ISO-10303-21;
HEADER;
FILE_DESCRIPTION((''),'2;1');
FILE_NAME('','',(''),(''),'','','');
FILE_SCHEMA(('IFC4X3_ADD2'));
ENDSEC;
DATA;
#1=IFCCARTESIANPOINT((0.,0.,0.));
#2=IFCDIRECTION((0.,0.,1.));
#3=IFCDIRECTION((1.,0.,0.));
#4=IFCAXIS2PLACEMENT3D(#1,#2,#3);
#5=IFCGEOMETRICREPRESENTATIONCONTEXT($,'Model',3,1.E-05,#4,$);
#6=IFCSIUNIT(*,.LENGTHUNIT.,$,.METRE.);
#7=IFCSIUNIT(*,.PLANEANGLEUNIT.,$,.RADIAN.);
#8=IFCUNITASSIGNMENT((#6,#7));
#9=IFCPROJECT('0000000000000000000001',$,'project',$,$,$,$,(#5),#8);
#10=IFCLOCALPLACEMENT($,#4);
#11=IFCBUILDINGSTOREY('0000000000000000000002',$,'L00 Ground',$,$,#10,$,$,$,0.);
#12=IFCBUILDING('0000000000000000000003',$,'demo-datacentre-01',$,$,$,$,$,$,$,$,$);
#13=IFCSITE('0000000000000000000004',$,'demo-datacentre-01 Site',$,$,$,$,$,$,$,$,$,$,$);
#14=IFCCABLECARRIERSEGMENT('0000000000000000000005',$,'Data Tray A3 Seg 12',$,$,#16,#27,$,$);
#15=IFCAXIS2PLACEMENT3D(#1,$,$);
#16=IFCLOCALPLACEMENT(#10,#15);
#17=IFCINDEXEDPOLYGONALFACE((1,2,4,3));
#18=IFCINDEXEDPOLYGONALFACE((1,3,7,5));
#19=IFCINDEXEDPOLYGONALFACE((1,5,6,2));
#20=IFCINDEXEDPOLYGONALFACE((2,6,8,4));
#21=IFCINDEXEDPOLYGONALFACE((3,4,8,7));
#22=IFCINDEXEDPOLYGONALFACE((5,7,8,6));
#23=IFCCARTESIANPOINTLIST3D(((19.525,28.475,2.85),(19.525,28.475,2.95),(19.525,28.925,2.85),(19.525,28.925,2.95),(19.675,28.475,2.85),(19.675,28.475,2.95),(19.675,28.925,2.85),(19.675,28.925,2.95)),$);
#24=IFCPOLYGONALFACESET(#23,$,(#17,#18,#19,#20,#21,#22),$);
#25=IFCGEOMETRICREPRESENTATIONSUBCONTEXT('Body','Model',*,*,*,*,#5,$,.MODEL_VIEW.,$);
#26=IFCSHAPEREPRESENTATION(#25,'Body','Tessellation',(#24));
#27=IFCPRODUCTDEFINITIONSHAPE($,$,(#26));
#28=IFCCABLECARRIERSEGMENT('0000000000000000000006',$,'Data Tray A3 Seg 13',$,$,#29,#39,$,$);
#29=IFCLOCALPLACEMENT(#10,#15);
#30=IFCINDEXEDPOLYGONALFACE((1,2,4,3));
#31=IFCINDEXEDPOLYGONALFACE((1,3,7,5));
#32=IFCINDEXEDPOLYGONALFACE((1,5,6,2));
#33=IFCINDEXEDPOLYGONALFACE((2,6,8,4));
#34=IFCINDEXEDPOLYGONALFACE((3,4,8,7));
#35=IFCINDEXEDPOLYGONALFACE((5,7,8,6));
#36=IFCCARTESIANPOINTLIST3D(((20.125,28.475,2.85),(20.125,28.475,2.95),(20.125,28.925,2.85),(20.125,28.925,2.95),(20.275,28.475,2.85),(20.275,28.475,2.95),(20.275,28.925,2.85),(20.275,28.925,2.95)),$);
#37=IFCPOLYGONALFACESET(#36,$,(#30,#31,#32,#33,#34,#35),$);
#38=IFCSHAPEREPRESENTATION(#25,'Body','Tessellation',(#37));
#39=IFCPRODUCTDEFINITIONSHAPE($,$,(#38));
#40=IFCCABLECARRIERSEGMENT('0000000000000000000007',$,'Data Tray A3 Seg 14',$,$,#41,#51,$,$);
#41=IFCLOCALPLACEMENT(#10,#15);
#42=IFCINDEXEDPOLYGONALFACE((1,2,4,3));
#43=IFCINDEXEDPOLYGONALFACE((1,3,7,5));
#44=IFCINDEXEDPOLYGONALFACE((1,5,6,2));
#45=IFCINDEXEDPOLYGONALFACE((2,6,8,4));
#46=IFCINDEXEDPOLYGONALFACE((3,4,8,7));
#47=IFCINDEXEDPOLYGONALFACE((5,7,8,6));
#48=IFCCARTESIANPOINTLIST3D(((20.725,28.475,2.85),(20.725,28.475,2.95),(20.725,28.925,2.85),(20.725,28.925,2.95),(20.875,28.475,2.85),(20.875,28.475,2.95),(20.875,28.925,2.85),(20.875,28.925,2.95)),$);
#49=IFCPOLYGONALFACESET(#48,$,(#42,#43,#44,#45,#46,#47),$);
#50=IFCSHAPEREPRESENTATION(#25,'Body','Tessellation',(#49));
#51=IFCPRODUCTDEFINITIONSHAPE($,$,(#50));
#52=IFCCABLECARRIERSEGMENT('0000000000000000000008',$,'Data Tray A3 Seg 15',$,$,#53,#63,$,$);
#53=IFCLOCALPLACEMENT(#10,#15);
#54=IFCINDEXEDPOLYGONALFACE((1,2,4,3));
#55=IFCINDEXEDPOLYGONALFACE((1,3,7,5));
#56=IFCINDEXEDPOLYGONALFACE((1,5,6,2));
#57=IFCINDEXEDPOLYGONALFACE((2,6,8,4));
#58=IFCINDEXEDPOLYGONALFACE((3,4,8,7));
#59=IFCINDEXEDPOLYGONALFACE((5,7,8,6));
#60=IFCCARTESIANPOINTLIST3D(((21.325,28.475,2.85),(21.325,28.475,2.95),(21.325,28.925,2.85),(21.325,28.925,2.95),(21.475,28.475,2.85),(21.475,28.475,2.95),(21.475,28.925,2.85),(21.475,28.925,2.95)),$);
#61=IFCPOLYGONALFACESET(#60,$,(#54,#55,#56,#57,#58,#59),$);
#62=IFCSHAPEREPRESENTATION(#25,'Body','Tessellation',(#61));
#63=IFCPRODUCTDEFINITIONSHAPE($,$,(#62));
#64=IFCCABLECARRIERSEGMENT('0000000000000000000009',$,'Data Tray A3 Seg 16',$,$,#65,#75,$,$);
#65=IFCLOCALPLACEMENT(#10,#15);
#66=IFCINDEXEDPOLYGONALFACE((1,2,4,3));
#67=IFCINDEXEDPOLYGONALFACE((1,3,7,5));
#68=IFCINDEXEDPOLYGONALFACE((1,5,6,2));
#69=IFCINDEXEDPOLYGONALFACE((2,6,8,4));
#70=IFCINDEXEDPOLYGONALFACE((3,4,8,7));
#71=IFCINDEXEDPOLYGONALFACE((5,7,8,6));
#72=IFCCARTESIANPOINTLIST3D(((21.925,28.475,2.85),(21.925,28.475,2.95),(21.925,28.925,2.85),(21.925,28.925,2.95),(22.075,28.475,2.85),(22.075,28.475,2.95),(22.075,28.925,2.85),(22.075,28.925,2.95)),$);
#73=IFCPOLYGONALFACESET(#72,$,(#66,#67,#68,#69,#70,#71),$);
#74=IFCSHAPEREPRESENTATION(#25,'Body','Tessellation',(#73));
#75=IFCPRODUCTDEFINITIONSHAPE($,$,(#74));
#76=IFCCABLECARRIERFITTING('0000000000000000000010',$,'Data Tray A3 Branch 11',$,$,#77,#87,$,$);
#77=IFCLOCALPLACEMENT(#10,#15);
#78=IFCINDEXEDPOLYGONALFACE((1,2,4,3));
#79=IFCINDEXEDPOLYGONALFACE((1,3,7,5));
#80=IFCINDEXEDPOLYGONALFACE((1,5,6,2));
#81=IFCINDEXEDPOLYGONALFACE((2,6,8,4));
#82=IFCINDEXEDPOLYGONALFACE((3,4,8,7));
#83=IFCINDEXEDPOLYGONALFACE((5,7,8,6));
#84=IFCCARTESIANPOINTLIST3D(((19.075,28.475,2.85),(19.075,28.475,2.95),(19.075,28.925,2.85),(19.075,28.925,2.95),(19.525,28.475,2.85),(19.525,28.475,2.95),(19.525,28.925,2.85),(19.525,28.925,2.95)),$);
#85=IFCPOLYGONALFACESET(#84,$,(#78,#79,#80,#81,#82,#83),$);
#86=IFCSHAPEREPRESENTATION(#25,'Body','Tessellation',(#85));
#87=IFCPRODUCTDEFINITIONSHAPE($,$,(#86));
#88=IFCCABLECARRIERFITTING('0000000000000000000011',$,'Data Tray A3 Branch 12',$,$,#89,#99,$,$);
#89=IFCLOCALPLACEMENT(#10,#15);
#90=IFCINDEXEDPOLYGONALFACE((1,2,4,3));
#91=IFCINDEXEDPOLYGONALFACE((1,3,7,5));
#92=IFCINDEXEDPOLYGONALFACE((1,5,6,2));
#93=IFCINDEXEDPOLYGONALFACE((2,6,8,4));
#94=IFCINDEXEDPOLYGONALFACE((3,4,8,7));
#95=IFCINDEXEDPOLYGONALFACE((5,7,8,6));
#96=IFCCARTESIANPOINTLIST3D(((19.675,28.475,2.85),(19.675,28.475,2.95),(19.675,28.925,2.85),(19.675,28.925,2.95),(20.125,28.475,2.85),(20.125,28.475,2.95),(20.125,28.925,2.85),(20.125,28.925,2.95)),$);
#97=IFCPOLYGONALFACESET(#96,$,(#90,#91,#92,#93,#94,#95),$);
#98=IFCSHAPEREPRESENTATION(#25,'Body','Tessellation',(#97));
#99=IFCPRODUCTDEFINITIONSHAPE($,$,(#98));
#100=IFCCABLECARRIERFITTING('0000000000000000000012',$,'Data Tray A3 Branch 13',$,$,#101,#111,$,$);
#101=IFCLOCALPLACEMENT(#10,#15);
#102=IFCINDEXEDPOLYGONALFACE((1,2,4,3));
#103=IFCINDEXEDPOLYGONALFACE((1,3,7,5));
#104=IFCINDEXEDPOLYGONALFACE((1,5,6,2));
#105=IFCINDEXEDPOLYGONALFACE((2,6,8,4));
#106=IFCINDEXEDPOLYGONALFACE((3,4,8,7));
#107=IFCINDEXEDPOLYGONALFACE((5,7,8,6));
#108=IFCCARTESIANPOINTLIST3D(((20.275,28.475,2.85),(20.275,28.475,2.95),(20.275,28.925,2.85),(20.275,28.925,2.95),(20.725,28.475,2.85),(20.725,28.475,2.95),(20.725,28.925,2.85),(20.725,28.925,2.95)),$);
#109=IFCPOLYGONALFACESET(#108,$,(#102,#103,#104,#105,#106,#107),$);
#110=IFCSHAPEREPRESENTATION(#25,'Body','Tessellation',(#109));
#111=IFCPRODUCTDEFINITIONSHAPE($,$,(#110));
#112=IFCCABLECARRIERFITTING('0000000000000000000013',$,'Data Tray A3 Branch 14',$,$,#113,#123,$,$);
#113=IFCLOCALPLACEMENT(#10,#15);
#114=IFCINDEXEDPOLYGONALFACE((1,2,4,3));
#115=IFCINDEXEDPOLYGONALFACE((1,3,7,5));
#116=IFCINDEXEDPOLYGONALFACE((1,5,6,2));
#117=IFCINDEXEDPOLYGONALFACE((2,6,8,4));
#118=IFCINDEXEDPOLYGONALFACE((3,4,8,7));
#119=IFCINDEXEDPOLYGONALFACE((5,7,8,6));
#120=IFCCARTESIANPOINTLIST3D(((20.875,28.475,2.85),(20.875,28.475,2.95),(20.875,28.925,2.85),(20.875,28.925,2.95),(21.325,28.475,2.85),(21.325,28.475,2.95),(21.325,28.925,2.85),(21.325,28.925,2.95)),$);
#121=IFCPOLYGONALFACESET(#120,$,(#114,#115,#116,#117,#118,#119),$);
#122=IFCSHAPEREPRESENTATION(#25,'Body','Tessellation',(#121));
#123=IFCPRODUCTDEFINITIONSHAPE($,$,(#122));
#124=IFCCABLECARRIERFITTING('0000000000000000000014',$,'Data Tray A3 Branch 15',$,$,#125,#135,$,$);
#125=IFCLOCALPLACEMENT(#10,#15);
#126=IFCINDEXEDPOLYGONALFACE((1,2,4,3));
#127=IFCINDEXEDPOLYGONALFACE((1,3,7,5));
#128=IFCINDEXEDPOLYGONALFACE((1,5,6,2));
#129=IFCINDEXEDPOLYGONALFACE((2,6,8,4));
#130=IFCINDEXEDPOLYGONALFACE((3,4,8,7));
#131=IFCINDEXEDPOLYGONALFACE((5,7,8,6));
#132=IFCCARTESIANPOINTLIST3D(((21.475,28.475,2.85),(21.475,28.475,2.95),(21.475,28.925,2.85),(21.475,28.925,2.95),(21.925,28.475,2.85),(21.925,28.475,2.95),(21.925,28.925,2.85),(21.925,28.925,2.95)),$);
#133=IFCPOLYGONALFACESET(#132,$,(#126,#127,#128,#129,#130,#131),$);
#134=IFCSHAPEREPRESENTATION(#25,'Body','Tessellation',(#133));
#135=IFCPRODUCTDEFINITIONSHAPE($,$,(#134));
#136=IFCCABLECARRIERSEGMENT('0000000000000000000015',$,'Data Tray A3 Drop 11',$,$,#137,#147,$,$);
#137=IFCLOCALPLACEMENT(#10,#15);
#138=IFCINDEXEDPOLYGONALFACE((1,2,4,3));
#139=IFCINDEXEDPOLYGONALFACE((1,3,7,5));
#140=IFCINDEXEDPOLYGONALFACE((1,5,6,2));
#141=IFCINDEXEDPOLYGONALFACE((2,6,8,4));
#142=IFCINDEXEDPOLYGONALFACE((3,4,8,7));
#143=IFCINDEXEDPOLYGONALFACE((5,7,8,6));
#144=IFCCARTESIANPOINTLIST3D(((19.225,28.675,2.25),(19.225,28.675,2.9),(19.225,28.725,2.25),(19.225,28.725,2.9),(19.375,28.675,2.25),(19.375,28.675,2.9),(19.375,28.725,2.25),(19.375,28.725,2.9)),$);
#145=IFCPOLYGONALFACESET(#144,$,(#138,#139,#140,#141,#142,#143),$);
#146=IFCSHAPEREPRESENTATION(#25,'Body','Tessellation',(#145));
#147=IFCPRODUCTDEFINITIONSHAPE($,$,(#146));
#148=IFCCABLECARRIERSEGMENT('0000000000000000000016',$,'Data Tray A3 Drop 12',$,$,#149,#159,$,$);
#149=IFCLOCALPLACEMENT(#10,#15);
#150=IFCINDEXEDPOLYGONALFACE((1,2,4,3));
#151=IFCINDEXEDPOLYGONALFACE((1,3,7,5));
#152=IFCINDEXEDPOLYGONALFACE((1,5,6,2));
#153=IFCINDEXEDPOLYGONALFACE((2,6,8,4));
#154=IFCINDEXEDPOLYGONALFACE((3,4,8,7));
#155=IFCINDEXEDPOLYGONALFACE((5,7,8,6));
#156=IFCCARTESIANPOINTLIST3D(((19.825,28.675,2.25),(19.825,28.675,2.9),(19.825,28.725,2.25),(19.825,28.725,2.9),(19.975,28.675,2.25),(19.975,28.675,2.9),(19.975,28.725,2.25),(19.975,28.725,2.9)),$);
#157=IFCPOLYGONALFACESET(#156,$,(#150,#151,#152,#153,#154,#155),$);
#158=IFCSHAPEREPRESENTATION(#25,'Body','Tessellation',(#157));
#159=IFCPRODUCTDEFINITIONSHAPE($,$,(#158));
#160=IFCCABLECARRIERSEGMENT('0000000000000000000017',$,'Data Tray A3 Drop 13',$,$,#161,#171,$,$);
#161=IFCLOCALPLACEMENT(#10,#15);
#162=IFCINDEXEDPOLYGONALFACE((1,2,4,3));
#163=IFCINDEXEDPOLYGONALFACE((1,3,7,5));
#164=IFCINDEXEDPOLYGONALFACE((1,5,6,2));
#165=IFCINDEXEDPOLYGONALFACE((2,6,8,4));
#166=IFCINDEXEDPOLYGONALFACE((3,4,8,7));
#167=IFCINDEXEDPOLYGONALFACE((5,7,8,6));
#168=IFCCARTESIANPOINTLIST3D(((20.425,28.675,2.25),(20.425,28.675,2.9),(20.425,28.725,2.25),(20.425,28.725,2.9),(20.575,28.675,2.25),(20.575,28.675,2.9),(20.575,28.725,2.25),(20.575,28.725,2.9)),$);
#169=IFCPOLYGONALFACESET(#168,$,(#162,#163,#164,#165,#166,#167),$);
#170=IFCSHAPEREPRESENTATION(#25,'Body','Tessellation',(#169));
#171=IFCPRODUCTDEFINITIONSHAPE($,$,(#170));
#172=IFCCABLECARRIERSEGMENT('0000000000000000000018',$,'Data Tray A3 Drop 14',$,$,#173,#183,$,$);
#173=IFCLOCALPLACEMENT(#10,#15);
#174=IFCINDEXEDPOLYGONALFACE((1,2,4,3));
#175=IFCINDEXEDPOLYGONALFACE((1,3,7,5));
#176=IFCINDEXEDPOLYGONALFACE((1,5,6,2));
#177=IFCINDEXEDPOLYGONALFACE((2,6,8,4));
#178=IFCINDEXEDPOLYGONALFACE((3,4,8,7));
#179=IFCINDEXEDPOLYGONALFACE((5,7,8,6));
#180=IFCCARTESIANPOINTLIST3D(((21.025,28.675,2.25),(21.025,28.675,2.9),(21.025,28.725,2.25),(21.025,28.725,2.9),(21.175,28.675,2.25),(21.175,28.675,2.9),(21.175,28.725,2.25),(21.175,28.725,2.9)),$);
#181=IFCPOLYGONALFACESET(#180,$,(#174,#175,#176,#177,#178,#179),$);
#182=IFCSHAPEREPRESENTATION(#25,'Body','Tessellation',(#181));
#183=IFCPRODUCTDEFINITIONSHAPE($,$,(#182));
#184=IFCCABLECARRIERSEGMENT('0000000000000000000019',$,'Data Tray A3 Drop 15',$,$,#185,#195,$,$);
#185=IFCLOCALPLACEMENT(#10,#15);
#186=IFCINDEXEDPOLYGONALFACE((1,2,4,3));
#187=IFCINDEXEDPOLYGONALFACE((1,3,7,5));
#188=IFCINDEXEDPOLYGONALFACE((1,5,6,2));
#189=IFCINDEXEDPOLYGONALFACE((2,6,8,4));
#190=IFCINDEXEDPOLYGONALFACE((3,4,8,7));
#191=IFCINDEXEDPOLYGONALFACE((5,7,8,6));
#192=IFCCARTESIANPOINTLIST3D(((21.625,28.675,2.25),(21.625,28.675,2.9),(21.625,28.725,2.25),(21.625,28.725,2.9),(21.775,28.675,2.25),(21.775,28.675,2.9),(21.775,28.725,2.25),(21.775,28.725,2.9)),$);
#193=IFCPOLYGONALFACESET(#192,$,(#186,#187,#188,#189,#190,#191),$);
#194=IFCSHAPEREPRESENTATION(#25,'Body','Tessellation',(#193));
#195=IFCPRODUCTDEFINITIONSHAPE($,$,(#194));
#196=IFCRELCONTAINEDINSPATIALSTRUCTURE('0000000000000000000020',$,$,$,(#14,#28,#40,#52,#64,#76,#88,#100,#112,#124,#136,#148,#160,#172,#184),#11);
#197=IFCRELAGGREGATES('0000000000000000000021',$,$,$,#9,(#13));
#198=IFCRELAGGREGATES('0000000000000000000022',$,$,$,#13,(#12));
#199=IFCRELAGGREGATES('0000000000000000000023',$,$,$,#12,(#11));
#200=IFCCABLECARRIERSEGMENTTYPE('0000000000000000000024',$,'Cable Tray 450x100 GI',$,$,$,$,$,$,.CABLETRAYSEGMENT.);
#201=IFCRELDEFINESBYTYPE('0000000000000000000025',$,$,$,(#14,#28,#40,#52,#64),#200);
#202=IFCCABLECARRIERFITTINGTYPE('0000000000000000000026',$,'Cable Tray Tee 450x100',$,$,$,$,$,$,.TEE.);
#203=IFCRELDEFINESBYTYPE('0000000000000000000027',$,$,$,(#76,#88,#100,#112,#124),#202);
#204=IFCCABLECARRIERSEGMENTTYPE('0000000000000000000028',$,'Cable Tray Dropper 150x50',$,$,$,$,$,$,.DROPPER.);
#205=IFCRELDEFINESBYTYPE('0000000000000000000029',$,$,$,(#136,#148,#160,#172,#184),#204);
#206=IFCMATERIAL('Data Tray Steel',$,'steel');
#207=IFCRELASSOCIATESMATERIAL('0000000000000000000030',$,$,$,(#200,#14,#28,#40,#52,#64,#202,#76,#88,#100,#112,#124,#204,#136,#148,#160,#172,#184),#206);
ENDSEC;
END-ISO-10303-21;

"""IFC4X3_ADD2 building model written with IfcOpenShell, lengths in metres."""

from ifc_helpers import new_model, si_unit, frame, origin_with_axes, place, context, subcontext, project, spatial, rectangle, extrude, material, type_object, element, save


model = new_model("IFC4X3_ADD2")

# Units and contexts
model_context = context("Model", 3, precision=1e-05, world=origin_with_axes())
body_context = subcontext(model_context, "Body", "Model", "MODEL_VIEW")
ifc_project = project(units=[si_unit("LENGTHUNIT", "METRE"), si_unit("PLANEANGLEUNIT", "RADIAN")], contexts=[model_context])

# Site, building, storey
site = spatial("IfcSite", under=ifc_project, Name="demo-datacentre-01 Site")
building = spatial("IfcBuilding", under=site, Name="demo-datacentre-01")
storey_placement = place(None, origin_with_axes())
storey = spatial("IfcBuildingStorey", under=building, at=storey_placement, Name="L00 Ground", Elevation=0.0)

# Cable carrier segments
ifc_material_1 = material(Name="Data Tray Steel", Category="steel")
cable_carrier_segment_type_1 = type_object("IfcCableCarrierSegmentType", Name="Cable Tray 450x100 GI", PredefinedType="CABLETRAYSEGMENT", material=ifc_material_1)
cable_carrier_segment_1_placement = place(storey_placement, frame((19.525, 28.7, 2.9), z_axis=(1.0, 0.0, 0.0), x_axis=(0.0, 1.0, 0.0)))
element("IfcCableCarrierSegment", 1, at=cable_carrier_segment_1_placement, inside=storey, type_object=cable_carrier_segment_type_1, material=ifc_material_1, Name="Data Tray A3 Seg 12", context=body_context, shape_type="SweptSolid", body=[
    extrude(rectangle(XDim=0.45, YDim=0.1), origin_with_axes(), (0.0, 0.0, 1.0), 0.15),
])
for number, where, z_axis, x_axis, name in (
    (2, (20.125, 28.7, 2.9), (1.0, 0.0, 0.0), (0.0, 1.0, 0.0), "Data Tray A3 Seg 13"),
    (3, (20.725, 28.7, 2.9), (1.0, 0.0, 0.0), (0.0, 1.0, 0.0), "Data Tray A3 Seg 14"),
    (4, (21.325, 28.7, 2.9), (1.0, 0.0, 0.0), (0.0, 1.0, 0.0), "Data Tray A3 Seg 15"),
):
    element("IfcCableCarrierSegment", number, at=place(storey_placement, frame(where, z_axis=z_axis, x_axis=x_axis)), inside=storey, type_object=cable_carrier_segment_type_1, material=ifc_material_1, Name=name, context=body_context, shape_type="SweptSolid", body=[
        extrude(rectangle(XDim=0.45, YDim=0.1), origin_with_axes(), (0.0, 0.0, 1.0), 0.15),
    ])
cable_carrier_segment_2_placement = place(storey_placement, frame((21.925, 28.7, 2.9), z_axis=(1.0, 0.0, 0.0), x_axis=(0.0, 1.0, 0.0)))
element("IfcCableCarrierSegment", 5, at=cable_carrier_segment_2_placement, inside=storey, type_object=cable_carrier_segment_type_1, material=ifc_material_1, Name="Data Tray A3 Seg 16", context=body_context, shape_type="SweptSolid", body=[
    extrude(rectangle(XDim=0.45, YDim=0.1), origin_with_axes(), (0.0, 0.0, 1.0), 0.15),
])

# Cable carrier fittings
cable_carrier_fitting_type = type_object("IfcCableCarrierFittingType", Name="Cable Tray Tee 450x100", PredefinedType="TEE", material=ifc_material_1)
for number, where, z_axis, x_axis, name in (
    (6, (19.3, 28.7, 2.85), (0.0, 0.0, 1.0), (1.0, 0.0, 0.0), "Data Tray A3 Branch 11"),
    (7, (19.9, 28.7, 2.85), (0.0, 0.0, 1.0), (1.0, 0.0, 0.0), "Data Tray A3 Branch 12"),
    (8, (20.5, 28.7, 2.85), (0.0, 0.0, 1.0), (1.0, 0.0, 0.0), "Data Tray A3 Branch 13"),
    (9, (21.1, 28.7, 2.85), (0.0, 0.0, 1.0), (1.0, 0.0, 0.0), "Data Tray A3 Branch 14"),
    (10, (21.7, 28.7, 2.85), (0.0, 0.0, 1.0), (1.0, 0.0, 0.0), "Data Tray A3 Branch 15"),
):
    element("IfcCableCarrierFitting", number, at=place(storey_placement, frame(where, z_axis=z_axis, x_axis=x_axis)), inside=storey, type_object=cable_carrier_fitting_type, material=ifc_material_1, Name=name, context=body_context, shape_type="SweptSolid", body=[
        extrude(rectangle(XDim=0.45, YDim=0.45), origin_with_axes(), (0.0, 0.0, 1.0), 0.1),
    ])

# Cable carrier segments
cable_carrier_segment_type_2 = type_object("IfcCableCarrierSegmentType", Name="Cable Tray Dropper 150x50", PredefinedType="DROPPER", material=ifc_material_1)
for number, where, z_axis, x_axis, name in (
    (11, (19.3, 28.7, 2.9), (0.0, 0.0, -1.0), (1.0, 0.0, 0.0), "Data Tray A3 Drop 11"),
    (12, (19.9, 28.7, 2.9), (0.0, 0.0, -1.0), (1.0, 0.0, 0.0), "Data Tray A3 Drop 12"),
    (13, (20.5, 28.7, 2.9), (0.0, 0.0, -1.0), (1.0, 0.0, 0.0), "Data Tray A3 Drop 13"),
    (14, (21.1, 28.7, 2.9), (0.0, 0.0, -1.0), (1.0, 0.0, 0.0), "Data Tray A3 Drop 14"),
    (15, (21.7, 28.7, 2.9), (0.0, 0.0, -1.0), (1.0, 0.0, 0.0), "Data Tray A3 Drop 15"),
):
    element("IfcCableCarrierSegment", number, at=place(storey_placement, frame(where, z_axis=z_axis, x_axis=x_axis)), inside=storey, type_object=cable_carrier_segment_type_2, material=ifc_material_1, Name=name, context=body_context, shape_type="SweptSolid", body=[
        extrude(rectangle(XDim=0.15, YDim=0.05), origin_with_axes(), (0.0, 0.0, 1.0), 0.65),
    ])

save(model, "model.ifc")
